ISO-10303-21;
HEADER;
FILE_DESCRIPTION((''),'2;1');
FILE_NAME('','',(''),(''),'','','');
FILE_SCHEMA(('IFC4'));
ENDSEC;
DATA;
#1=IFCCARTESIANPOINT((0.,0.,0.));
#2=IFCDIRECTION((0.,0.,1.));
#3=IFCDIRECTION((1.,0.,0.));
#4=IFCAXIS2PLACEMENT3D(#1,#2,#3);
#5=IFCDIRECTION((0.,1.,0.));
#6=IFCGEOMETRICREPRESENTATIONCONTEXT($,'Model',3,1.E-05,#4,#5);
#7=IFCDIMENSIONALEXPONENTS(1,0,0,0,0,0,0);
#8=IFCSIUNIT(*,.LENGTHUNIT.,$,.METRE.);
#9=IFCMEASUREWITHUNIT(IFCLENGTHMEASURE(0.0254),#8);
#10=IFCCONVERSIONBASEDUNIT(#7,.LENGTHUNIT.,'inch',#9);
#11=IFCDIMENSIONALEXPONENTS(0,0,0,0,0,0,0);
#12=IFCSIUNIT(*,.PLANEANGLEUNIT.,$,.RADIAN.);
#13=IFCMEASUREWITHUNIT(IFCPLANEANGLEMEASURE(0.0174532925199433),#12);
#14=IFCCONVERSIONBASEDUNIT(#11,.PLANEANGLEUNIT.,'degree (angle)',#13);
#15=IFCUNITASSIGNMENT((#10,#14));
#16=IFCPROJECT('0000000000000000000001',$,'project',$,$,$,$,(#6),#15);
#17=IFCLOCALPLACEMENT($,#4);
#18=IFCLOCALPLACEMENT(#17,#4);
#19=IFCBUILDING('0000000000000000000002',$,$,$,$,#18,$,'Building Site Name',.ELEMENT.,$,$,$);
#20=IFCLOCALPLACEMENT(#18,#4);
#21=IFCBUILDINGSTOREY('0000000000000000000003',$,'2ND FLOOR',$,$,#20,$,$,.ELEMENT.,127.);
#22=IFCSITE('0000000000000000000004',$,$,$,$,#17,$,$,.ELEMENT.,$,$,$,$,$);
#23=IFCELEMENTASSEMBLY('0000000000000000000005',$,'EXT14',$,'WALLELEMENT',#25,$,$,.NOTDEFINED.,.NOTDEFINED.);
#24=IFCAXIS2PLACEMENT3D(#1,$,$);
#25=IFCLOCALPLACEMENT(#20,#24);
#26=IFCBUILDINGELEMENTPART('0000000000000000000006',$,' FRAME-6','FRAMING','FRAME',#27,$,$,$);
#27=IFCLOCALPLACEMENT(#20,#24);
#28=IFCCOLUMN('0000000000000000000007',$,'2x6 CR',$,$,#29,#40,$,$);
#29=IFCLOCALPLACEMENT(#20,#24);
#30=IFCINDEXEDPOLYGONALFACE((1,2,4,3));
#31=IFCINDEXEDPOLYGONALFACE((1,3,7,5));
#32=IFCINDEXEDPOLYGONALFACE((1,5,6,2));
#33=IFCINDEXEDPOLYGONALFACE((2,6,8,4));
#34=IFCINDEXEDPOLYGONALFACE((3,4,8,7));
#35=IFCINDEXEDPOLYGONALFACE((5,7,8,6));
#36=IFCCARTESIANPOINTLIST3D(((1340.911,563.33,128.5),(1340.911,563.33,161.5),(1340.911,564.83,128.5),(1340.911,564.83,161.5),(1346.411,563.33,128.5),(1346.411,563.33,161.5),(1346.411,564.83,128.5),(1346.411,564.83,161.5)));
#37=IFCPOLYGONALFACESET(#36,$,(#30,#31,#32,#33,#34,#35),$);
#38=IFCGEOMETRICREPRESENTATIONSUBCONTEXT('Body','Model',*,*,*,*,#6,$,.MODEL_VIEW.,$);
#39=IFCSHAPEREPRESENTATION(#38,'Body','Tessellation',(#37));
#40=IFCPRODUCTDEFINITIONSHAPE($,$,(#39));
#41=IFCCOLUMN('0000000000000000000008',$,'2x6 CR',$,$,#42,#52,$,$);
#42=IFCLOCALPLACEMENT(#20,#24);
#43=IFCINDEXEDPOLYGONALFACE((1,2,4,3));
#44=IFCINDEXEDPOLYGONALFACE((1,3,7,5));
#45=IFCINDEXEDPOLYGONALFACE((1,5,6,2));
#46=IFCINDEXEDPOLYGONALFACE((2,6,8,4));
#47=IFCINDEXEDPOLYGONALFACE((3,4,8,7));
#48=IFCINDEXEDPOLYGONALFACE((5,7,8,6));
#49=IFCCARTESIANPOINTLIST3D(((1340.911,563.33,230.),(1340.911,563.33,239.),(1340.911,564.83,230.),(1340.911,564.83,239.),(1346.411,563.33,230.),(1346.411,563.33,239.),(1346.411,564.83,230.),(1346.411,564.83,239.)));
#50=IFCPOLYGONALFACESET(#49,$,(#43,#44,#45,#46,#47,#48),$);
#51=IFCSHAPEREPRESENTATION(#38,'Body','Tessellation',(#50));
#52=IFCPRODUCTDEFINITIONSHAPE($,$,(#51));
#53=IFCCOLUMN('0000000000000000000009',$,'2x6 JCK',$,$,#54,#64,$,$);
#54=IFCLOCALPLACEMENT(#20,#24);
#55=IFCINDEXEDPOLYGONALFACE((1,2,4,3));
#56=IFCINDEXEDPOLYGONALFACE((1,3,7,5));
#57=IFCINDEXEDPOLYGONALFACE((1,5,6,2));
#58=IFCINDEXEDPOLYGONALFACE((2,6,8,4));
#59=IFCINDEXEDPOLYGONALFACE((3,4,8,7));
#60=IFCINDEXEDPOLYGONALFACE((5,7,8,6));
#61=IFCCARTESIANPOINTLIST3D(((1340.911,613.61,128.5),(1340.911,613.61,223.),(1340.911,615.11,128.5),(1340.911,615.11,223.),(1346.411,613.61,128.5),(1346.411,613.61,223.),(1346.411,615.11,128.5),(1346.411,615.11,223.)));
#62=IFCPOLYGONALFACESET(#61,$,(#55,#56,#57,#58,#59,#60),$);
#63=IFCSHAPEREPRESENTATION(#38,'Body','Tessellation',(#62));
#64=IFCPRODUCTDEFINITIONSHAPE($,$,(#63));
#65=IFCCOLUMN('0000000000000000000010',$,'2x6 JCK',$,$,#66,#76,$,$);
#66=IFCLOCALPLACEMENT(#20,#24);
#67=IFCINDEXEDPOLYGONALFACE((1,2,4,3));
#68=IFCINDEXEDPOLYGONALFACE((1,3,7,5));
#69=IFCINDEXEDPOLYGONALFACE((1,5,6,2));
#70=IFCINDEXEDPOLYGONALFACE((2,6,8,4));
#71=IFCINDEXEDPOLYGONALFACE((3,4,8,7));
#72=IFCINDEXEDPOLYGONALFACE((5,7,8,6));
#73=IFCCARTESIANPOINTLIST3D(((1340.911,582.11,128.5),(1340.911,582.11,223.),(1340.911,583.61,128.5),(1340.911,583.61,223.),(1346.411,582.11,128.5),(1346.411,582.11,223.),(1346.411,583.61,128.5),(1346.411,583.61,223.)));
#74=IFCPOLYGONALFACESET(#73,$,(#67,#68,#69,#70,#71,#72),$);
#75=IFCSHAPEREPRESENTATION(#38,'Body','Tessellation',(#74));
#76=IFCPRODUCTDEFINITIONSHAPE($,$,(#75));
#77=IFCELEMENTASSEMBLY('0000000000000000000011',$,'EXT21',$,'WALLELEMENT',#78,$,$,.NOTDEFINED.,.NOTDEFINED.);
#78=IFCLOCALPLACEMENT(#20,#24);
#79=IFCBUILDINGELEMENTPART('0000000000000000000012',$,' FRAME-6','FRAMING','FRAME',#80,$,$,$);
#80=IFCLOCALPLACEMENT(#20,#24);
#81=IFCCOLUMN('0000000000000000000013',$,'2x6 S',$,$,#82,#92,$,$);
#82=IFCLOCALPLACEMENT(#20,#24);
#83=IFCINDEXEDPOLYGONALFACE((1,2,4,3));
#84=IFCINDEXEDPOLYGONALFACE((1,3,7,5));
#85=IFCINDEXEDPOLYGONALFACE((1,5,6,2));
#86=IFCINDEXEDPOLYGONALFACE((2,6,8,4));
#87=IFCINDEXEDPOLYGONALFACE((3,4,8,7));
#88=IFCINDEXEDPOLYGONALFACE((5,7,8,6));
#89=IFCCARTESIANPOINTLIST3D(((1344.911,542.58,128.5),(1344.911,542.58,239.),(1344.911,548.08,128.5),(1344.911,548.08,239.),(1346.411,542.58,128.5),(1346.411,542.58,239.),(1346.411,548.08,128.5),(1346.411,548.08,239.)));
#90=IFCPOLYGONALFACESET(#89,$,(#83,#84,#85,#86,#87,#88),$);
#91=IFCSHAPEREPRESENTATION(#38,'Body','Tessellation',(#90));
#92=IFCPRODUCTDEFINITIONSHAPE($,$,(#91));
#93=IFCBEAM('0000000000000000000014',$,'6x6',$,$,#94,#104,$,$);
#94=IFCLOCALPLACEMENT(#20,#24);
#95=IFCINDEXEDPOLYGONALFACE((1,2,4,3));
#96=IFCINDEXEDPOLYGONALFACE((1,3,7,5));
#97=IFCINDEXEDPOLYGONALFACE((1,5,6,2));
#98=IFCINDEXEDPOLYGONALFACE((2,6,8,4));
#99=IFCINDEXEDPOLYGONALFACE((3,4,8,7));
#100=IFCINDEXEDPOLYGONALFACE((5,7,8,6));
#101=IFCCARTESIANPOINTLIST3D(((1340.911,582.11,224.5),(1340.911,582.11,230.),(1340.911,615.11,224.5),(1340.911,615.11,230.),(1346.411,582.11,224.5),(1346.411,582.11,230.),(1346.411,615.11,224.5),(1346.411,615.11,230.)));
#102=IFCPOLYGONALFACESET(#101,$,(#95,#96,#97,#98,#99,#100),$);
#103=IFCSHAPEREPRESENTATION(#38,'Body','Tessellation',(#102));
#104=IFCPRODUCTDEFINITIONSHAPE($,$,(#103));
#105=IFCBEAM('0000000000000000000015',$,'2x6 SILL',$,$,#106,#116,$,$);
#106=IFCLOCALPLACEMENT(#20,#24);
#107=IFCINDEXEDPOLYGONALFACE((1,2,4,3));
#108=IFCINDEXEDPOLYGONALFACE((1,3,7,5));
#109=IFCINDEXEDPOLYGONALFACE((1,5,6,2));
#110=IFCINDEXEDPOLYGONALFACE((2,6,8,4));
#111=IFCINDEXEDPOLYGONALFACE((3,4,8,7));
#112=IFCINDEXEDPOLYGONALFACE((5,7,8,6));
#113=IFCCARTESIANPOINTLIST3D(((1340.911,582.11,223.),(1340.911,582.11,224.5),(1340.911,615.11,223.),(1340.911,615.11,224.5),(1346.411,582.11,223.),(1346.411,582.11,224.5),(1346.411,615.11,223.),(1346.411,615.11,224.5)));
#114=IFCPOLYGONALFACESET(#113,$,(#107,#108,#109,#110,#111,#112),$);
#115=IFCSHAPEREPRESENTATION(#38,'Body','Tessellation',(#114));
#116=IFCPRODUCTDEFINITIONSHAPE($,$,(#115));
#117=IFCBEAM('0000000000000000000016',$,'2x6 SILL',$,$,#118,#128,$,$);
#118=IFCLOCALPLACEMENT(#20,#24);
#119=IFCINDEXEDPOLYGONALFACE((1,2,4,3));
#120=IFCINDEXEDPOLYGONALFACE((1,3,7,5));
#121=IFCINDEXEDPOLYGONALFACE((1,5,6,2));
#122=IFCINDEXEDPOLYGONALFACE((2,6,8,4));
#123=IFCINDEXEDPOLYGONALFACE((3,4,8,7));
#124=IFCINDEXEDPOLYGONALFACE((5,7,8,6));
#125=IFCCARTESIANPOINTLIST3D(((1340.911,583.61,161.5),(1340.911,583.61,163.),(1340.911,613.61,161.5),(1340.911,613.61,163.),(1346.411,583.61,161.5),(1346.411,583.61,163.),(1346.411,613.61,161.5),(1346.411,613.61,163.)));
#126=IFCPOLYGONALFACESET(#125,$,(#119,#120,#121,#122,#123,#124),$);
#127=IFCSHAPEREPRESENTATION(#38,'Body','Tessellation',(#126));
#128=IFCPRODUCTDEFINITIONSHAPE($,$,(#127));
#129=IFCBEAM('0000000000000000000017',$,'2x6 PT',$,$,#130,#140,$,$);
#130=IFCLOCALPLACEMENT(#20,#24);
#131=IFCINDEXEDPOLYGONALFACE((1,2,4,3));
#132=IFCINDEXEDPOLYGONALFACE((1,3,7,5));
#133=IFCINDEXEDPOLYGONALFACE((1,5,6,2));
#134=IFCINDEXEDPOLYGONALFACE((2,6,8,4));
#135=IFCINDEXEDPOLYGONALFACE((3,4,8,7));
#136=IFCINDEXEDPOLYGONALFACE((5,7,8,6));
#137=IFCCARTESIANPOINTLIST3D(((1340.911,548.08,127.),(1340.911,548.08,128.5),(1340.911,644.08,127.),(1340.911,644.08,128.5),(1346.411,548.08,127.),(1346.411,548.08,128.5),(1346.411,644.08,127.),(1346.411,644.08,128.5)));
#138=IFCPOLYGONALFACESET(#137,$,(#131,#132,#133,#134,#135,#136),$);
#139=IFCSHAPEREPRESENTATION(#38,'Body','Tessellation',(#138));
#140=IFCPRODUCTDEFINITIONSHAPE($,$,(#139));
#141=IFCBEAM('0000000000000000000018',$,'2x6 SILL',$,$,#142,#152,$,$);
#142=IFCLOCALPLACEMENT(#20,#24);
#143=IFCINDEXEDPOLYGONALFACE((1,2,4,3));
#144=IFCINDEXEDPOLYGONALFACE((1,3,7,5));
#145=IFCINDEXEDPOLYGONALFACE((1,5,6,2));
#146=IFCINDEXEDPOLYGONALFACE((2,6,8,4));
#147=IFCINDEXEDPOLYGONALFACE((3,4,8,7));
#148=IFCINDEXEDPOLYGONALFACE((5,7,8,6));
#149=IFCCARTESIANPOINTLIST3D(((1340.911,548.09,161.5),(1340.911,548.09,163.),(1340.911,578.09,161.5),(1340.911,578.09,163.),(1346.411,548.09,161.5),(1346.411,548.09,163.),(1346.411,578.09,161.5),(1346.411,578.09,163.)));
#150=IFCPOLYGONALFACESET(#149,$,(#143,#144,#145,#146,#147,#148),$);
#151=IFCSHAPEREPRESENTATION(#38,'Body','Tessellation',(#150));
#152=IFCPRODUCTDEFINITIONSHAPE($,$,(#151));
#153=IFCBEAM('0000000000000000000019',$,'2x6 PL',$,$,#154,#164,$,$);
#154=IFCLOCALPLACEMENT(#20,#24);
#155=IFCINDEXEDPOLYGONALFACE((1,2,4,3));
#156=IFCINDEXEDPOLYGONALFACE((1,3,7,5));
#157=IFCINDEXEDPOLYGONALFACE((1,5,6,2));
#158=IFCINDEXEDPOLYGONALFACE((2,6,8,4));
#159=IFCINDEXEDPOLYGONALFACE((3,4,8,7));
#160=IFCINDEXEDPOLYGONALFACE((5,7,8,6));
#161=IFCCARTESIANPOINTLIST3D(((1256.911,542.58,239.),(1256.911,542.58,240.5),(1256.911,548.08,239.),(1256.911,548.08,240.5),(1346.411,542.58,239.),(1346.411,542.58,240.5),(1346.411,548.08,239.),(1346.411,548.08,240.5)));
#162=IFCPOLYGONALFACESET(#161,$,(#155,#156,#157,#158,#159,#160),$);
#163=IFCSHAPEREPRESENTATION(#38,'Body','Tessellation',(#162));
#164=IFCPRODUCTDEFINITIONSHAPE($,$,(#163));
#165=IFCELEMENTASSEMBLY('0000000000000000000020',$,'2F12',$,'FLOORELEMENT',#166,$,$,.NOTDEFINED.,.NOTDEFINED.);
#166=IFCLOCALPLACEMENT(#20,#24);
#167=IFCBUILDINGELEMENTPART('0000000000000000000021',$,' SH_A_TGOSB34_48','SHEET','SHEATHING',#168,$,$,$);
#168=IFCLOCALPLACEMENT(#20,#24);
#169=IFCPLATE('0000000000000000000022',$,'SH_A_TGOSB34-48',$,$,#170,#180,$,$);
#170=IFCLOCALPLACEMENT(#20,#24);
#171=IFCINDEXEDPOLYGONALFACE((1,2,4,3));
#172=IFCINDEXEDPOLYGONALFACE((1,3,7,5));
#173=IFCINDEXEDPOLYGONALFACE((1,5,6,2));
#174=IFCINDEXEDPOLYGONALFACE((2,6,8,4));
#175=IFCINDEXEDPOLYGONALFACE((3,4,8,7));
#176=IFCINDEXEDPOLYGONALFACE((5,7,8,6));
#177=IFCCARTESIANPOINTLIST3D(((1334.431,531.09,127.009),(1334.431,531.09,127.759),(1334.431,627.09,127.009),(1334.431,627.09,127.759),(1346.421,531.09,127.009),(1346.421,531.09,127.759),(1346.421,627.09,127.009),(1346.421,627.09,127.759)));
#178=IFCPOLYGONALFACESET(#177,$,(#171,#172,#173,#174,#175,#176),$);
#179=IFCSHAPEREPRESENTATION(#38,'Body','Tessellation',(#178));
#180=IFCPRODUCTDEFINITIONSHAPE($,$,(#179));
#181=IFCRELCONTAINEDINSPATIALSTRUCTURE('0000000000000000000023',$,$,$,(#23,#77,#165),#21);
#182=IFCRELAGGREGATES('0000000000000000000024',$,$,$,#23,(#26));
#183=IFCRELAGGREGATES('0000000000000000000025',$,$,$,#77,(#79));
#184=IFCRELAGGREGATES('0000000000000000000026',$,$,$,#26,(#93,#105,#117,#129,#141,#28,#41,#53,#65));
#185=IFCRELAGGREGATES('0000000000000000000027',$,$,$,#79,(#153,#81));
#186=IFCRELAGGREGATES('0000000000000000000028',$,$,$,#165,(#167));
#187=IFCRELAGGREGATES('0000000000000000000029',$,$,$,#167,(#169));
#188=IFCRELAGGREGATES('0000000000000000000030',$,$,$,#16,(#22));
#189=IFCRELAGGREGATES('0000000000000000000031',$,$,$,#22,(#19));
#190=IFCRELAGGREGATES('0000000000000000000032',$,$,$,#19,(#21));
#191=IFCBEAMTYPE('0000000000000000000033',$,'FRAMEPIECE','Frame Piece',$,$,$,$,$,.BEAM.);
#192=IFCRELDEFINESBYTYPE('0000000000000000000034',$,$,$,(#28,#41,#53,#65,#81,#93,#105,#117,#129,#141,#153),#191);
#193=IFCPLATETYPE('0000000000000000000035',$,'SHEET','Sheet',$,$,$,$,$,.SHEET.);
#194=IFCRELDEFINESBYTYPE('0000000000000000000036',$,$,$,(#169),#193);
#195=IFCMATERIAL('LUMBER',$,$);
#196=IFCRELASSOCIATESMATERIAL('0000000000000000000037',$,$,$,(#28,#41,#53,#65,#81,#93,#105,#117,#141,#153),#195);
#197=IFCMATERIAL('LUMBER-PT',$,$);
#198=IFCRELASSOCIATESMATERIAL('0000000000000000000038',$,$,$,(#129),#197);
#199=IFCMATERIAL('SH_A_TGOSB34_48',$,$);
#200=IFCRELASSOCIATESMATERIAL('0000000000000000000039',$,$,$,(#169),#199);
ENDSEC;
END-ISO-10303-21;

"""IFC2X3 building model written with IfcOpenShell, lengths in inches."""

from ifc_helpers import new_model, entity, si_unit, converted_unit, direction, frame, frame_2d, origin_with_axes, place, context, subcontext, project, spatial, rectangle, extrude, material, type_object, element, aggregate, save


model = new_model("IFC2X3")

# Units and contexts
model_context = context("Model", 3, precision=1e-05, world=origin_with_axes(), true_north=direction((0.0, 1.0, 0.0)))
body_context = subcontext(model_context, "Body", "Model", "MODEL_VIEW")
ifc_project = project(units=[converted_unit("LENGTHUNIT", "inch", entity("IfcLengthMeasure", 0.0254), si_unit("LENGTHUNIT", "METRE"), dimensions=[1, 0, 0, 0, 0, 0, 0]), converted_unit("PLANEANGLEUNIT", "degree (angle)", entity("IfcPlaneAngleMeasure", 0.0174532925199433), si_unit("PLANEANGLEUNIT", "RADIAN"), dimensions=[0, 0, 0, 0, 0, 0, 0])], contexts=[model_context])

# Site, building, storey
site_placement = place(None, origin_with_axes())
site = spatial("IfcSite", under=ifc_project, at=site_placement, CompositionType="ELEMENT")
building_placement = place(site_placement, origin_with_axes())
building = spatial("IfcBuilding", under=site, at=building_placement, LongName="Building Site Name", CompositionType="ELEMENT")
storey_placement = place(building_placement, origin_with_axes())
storey = spatial("IfcBuildingStorey", under=building, at=storey_placement, Name="2ND FLOOR", CompositionType="ELEMENT", Elevation=127.0)

# Element assembly, building element part, columns
assembly_1_placement = place(storey_placement, origin_with_axes())
assembly_1 = element("IfcElementAssembly", 1, at=assembly_1_placement, inside=storey, Name="EXT14", ObjectType="WALLELEMENT", AssemblyPlace="NOTDEFINED", PredefinedType="NOTDEFINED")
building_element_part_1 = element("IfcBuildingElementPart", 2, Name=" FRAME-6", Description="FRAMING", ObjectType="FRAME")
aggregate(assembly_1, [building_element_part_1])
ifc_material_1 = material(Name="LUMBER")
beam_type = type_object("IfcBeamType", Name="FRAMEPIECE", Description="Frame Piece", PredefinedType="BEAM")
column_1_placement = place(assembly_1_placement, frame((1343.661, 564.08, 161.5), z_axis=(0.0, 0.0, -1.0), x_axis=(0.0, 1.0, 0.0)))
column_1 = element("IfcColumn", 3, at=column_1_placement, type_object=beam_type, material=ifc_material_1, Name="2x6 CR", context=body_context, shape_type="SweptSolid", body=[
    extrude(rectangle(XDim=1.5, YDim=5.5, at=frame_2d((0.0, 0.0), x_axis=(-1.0, 0.0))), origin_with_axes(), (0.0, 0.0, 1.0), 33.0),
])
column_2_placement = place(assembly_1_placement, frame((1343.661, 564.08, 239.0), z_axis=(0.0, 0.0, -1.0), x_axis=(0.0, 1.0, 0.0)))
column_2 = element("IfcColumn", 4, at=column_2_placement, type_object=beam_type, material=ifc_material_1, Name="2x6 CR", context=body_context, shape_type="SweptSolid", body=[
    extrude(rectangle(XDim=1.5, YDim=5.5, at=frame_2d((0.0, 0.0), x_axis=(-1.0, 0.0))), origin_with_axes(), (0.0, 0.0, 1.0), 9.0),
])
column_3_placement = place(assembly_1_placement, frame((1343.661, 614.36, 128.5), z_axis=(0.0, 0.0, 1.0), x_axis=(0.0, -1.0, 0.0)))
column_3 = element("IfcColumn", 5, at=column_3_placement, type_object=beam_type, material=ifc_material_1, Name="2x6 JCK", context=body_context, shape_type="SweptSolid", body=[
    extrude(rectangle(XDim=1.5, YDim=5.5, at=frame_2d((0.0, 0.0), x_axis=(-1.0, 0.0))), origin_with_axes(), (0.0, 0.0, 1.0), 94.5),
])
column_4_placement = place(assembly_1_placement, frame((1343.661, 582.86, 223.0), z_axis=(0.0, 0.0, -1.0), x_axis=(0.0, 1.0, 0.0)))
column_4 = element("IfcColumn", 6, at=column_4_placement, type_object=beam_type, material=ifc_material_1, Name="2x6 JCK", context=body_context, shape_type="SweptSolid", body=[
    extrude(rectangle(XDim=1.5, YDim=5.5, at=frame_2d((0.0, 0.0), x_axis=(-1.0, 0.0))), origin_with_axes(), (0.0, 0.0, 1.0), 94.5),
])

# Element assembly, building element part, column
assembly_2_placement = place(storey_placement, origin_with_axes())
assembly_2 = element("IfcElementAssembly", 7, at=assembly_2_placement, inside=storey, Name="EXT21", ObjectType="WALLELEMENT", AssemblyPlace="NOTDEFINED", PredefinedType="NOTDEFINED")
building_element_part_2 = element("IfcBuildingElementPart", 8, Name=" FRAME-6", Description="FRAMING", ObjectType="FRAME")
aggregate(assembly_2, [building_element_part_2])
column_5_placement = place(assembly_2_placement, frame((1345.661, 545.33, 128.5), z_axis=(0.0, 0.0, 1.0), x_axis=(-1.0, 0.0, 0.0)))
column_5 = element("IfcColumn", 9, at=column_5_placement, type_object=beam_type, material=ifc_material_1, Name="2x6 S", context=body_context, shape_type="SweptSolid", body=[
    extrude(rectangle(XDim=1.5, YDim=5.5, at=frame_2d((0.0, 0.0), x_axis=(-1.0, 0.0))), origin_with_axes(), (0.0, 0.0, 1.0), 110.5),
])

# Beams
beam_1_placement = place(assembly_1_placement, frame((1343.661, 582.11, 227.25), z_axis=(0.0, 1.0, 0.0), x_axis=(-1.0, 0.0, 0.0)))
beam_1 = element("IfcBeam", 10, at=beam_1_placement, type_object=beam_type, material=ifc_material_1, Name="6x6", context=body_context, shape_type="SweptSolid", body=[
    extrude(rectangle(XDim=5.5, YDim=5.5, at=frame_2d((0.0, 0.0), x_axis=(-1.0, 0.0))), frame((0.0, 0.0, 0.0), z_axis=(0.0, 0.0, 1.0), x_axis=(1.0, 0.0, 0.0)), (0.0, 0.0, 1.0), 33.0),
])
beam_2_placement = place(assembly_1_placement, frame((1343.661, 582.11, 223.75), z_axis=(0.0, 1.0, 0.0), x_axis=(0.0, 0.0, 1.0)))
beam_2 = element("IfcBeam", 11, at=beam_2_placement, type_object=beam_type, material=ifc_material_1, Name="2x6 SILL", context=body_context, shape_type="SweptSolid", body=[
    extrude(rectangle(XDim=1.5, YDim=5.5, at=frame_2d((0.0, 0.0), x_axis=(-1.0, 0.0))), frame((0.0, 0.0, 0.0), z_axis=(0.0, 0.0, 1.0), x_axis=(1.0, 0.0, 0.0)), (0.0, 0.0, 1.0), 33.0),
])
beam_3_placement = place(assembly_1_placement, frame((1343.661, 613.61, 162.25), z_axis=(0.0, -1.0, 0.0), x_axis=(0.0, 0.0, -1.0)))
beam_3 = element("IfcBeam", 12, at=beam_3_placement, type_object=beam_type, material=ifc_material_1, Name="2x6 SILL", context=body_context, shape_type="SweptSolid", body=[
    extrude(rectangle(XDim=1.5, YDim=5.5, at=frame_2d((0.0, 0.0), x_axis=(-1.0, 0.0))), frame((0.0, 0.0, 0.0), z_axis=(0.0, 0.0, 1.0), x_axis=(1.0, 0.0, 0.0)), (0.0, 0.0, 1.0), 30.0),
])
ifc_material_2 = material(Name="LUMBER-PT")
beam_4_placement = place(assembly_1_placement, frame((1343.661, 548.08, 127.75), z_axis=(0.0, 1.0, 0.0), x_axis=(0.0, 0.0, 1.0)))
beam_4 = element("IfcBeam", 13, at=beam_4_placement, type_object=beam_type, material=ifc_material_2, Name="2x6 PT", context=body_context, shape_type="SweptSolid", body=[
    extrude(rectangle(XDim=1.5, YDim=5.5, at=frame_2d((0.0, 0.0), x_axis=(-1.0, 0.0))), origin_with_axes(), (0.0, 0.0, 1.0), 96.0),
])
beam_5_placement = place(assembly_1_placement, frame((1343.661, 578.09, 162.25), z_axis=(0.0, -1.0, 0.0), x_axis=(0.0, 0.0, -1.0)))
beam_5 = element("IfcBeam", 14, at=beam_5_placement, type_object=beam_type, material=ifc_material_1, Name="2x6 SILL", context=body_context, shape_type="SweptSolid", body=[
    extrude(rectangle(XDim=1.5, YDim=5.5, at=frame_2d((0.0, 0.0), x_axis=(-1.0, 0.0))), frame((0.0, 0.0, 0.0), z_axis=(0.0, 0.0, 1.0), x_axis=(1.0, 0.0, 0.0)), (0.0, 0.0, 1.0), 30.0),
])
aggregate(building_element_part_1, [beam_1, beam_2, beam_3, beam_4, beam_5, column_1, column_2, column_3, column_4])
beam_6_placement = place(assembly_2_placement, frame((1346.411, 545.33, 239.75), z_axis=(-1.0, 0.0, 0.0), x_axis=(0.0, 0.0, -1.0)))
beam_6 = element("IfcBeam", 15, at=beam_6_placement, type_object=beam_type, material=ifc_material_1, Name="2x6 PL", context=body_context, shape_type="SweptSolid", body=[
    extrude(rectangle(XDim=1.5, YDim=5.5, at=frame_2d((0.0, 0.0), x_axis=(-1.0, 0.0))), frame((0.0, 0.0, 0.0), z_axis=(0.0, 0.0, 1.0), x_axis=(1.0, 0.0, 0.0)), (0.0, 0.0, 1.0), 89.5),
])
aggregate(building_element_part_2, [beam_6, column_5])

# Element assembly, building element part, plate
assembly_3_placement = place(storey_placement, origin_with_axes())
assembly_3 = element("IfcElementAssembly", 16, at=assembly_3_placement, inside=storey, Name="2F12", ObjectType="FLOORELEMENT", AssemblyPlace="NOTDEFINED", PredefinedType="NOTDEFINED")
building_element_part_3 = element("IfcBuildingElementPart", 17, Name=" SH_A_TGOSB34_48", Description="SHEET", ObjectType="SHEATHING")
aggregate(assembly_3, [building_element_part_3])
ifc_material_3 = material(Name="SH_A_TGOSB34_48")
plate_type = type_object("IfcPlateType", Name="SHEET", Description="Sheet", PredefinedType="SHEET")
plate_placement = place(assembly_3_placement, frame((1358.431, 579.09, 127.759), z_axis=(0.0, 0.0, 1.0), x_axis=(1.0, 0.0, 0.0)))
plate = element("IfcPlate", 18, at=plate_placement, type_object=plate_type, material=ifc_material_3, Name="SH_A_TGOSB34-48", context=body_context, shape_type="SweptSolid", body=[
    extrude(rectangle(XDim=0.75, YDim=11.99, at=frame_2d((18.005, -0.375), x_axis=(0.0, -1.0))), frame((0.0, -48.0, 0.0), z_axis=(0.0, 1.0, 0.0), x_axis=(-1.0, 0.0, 0.0)), (0.0, 0.0, 1.0), 96.0),
])
aggregate(building_element_part_3, [plate])

save(model, "model.ifc")
